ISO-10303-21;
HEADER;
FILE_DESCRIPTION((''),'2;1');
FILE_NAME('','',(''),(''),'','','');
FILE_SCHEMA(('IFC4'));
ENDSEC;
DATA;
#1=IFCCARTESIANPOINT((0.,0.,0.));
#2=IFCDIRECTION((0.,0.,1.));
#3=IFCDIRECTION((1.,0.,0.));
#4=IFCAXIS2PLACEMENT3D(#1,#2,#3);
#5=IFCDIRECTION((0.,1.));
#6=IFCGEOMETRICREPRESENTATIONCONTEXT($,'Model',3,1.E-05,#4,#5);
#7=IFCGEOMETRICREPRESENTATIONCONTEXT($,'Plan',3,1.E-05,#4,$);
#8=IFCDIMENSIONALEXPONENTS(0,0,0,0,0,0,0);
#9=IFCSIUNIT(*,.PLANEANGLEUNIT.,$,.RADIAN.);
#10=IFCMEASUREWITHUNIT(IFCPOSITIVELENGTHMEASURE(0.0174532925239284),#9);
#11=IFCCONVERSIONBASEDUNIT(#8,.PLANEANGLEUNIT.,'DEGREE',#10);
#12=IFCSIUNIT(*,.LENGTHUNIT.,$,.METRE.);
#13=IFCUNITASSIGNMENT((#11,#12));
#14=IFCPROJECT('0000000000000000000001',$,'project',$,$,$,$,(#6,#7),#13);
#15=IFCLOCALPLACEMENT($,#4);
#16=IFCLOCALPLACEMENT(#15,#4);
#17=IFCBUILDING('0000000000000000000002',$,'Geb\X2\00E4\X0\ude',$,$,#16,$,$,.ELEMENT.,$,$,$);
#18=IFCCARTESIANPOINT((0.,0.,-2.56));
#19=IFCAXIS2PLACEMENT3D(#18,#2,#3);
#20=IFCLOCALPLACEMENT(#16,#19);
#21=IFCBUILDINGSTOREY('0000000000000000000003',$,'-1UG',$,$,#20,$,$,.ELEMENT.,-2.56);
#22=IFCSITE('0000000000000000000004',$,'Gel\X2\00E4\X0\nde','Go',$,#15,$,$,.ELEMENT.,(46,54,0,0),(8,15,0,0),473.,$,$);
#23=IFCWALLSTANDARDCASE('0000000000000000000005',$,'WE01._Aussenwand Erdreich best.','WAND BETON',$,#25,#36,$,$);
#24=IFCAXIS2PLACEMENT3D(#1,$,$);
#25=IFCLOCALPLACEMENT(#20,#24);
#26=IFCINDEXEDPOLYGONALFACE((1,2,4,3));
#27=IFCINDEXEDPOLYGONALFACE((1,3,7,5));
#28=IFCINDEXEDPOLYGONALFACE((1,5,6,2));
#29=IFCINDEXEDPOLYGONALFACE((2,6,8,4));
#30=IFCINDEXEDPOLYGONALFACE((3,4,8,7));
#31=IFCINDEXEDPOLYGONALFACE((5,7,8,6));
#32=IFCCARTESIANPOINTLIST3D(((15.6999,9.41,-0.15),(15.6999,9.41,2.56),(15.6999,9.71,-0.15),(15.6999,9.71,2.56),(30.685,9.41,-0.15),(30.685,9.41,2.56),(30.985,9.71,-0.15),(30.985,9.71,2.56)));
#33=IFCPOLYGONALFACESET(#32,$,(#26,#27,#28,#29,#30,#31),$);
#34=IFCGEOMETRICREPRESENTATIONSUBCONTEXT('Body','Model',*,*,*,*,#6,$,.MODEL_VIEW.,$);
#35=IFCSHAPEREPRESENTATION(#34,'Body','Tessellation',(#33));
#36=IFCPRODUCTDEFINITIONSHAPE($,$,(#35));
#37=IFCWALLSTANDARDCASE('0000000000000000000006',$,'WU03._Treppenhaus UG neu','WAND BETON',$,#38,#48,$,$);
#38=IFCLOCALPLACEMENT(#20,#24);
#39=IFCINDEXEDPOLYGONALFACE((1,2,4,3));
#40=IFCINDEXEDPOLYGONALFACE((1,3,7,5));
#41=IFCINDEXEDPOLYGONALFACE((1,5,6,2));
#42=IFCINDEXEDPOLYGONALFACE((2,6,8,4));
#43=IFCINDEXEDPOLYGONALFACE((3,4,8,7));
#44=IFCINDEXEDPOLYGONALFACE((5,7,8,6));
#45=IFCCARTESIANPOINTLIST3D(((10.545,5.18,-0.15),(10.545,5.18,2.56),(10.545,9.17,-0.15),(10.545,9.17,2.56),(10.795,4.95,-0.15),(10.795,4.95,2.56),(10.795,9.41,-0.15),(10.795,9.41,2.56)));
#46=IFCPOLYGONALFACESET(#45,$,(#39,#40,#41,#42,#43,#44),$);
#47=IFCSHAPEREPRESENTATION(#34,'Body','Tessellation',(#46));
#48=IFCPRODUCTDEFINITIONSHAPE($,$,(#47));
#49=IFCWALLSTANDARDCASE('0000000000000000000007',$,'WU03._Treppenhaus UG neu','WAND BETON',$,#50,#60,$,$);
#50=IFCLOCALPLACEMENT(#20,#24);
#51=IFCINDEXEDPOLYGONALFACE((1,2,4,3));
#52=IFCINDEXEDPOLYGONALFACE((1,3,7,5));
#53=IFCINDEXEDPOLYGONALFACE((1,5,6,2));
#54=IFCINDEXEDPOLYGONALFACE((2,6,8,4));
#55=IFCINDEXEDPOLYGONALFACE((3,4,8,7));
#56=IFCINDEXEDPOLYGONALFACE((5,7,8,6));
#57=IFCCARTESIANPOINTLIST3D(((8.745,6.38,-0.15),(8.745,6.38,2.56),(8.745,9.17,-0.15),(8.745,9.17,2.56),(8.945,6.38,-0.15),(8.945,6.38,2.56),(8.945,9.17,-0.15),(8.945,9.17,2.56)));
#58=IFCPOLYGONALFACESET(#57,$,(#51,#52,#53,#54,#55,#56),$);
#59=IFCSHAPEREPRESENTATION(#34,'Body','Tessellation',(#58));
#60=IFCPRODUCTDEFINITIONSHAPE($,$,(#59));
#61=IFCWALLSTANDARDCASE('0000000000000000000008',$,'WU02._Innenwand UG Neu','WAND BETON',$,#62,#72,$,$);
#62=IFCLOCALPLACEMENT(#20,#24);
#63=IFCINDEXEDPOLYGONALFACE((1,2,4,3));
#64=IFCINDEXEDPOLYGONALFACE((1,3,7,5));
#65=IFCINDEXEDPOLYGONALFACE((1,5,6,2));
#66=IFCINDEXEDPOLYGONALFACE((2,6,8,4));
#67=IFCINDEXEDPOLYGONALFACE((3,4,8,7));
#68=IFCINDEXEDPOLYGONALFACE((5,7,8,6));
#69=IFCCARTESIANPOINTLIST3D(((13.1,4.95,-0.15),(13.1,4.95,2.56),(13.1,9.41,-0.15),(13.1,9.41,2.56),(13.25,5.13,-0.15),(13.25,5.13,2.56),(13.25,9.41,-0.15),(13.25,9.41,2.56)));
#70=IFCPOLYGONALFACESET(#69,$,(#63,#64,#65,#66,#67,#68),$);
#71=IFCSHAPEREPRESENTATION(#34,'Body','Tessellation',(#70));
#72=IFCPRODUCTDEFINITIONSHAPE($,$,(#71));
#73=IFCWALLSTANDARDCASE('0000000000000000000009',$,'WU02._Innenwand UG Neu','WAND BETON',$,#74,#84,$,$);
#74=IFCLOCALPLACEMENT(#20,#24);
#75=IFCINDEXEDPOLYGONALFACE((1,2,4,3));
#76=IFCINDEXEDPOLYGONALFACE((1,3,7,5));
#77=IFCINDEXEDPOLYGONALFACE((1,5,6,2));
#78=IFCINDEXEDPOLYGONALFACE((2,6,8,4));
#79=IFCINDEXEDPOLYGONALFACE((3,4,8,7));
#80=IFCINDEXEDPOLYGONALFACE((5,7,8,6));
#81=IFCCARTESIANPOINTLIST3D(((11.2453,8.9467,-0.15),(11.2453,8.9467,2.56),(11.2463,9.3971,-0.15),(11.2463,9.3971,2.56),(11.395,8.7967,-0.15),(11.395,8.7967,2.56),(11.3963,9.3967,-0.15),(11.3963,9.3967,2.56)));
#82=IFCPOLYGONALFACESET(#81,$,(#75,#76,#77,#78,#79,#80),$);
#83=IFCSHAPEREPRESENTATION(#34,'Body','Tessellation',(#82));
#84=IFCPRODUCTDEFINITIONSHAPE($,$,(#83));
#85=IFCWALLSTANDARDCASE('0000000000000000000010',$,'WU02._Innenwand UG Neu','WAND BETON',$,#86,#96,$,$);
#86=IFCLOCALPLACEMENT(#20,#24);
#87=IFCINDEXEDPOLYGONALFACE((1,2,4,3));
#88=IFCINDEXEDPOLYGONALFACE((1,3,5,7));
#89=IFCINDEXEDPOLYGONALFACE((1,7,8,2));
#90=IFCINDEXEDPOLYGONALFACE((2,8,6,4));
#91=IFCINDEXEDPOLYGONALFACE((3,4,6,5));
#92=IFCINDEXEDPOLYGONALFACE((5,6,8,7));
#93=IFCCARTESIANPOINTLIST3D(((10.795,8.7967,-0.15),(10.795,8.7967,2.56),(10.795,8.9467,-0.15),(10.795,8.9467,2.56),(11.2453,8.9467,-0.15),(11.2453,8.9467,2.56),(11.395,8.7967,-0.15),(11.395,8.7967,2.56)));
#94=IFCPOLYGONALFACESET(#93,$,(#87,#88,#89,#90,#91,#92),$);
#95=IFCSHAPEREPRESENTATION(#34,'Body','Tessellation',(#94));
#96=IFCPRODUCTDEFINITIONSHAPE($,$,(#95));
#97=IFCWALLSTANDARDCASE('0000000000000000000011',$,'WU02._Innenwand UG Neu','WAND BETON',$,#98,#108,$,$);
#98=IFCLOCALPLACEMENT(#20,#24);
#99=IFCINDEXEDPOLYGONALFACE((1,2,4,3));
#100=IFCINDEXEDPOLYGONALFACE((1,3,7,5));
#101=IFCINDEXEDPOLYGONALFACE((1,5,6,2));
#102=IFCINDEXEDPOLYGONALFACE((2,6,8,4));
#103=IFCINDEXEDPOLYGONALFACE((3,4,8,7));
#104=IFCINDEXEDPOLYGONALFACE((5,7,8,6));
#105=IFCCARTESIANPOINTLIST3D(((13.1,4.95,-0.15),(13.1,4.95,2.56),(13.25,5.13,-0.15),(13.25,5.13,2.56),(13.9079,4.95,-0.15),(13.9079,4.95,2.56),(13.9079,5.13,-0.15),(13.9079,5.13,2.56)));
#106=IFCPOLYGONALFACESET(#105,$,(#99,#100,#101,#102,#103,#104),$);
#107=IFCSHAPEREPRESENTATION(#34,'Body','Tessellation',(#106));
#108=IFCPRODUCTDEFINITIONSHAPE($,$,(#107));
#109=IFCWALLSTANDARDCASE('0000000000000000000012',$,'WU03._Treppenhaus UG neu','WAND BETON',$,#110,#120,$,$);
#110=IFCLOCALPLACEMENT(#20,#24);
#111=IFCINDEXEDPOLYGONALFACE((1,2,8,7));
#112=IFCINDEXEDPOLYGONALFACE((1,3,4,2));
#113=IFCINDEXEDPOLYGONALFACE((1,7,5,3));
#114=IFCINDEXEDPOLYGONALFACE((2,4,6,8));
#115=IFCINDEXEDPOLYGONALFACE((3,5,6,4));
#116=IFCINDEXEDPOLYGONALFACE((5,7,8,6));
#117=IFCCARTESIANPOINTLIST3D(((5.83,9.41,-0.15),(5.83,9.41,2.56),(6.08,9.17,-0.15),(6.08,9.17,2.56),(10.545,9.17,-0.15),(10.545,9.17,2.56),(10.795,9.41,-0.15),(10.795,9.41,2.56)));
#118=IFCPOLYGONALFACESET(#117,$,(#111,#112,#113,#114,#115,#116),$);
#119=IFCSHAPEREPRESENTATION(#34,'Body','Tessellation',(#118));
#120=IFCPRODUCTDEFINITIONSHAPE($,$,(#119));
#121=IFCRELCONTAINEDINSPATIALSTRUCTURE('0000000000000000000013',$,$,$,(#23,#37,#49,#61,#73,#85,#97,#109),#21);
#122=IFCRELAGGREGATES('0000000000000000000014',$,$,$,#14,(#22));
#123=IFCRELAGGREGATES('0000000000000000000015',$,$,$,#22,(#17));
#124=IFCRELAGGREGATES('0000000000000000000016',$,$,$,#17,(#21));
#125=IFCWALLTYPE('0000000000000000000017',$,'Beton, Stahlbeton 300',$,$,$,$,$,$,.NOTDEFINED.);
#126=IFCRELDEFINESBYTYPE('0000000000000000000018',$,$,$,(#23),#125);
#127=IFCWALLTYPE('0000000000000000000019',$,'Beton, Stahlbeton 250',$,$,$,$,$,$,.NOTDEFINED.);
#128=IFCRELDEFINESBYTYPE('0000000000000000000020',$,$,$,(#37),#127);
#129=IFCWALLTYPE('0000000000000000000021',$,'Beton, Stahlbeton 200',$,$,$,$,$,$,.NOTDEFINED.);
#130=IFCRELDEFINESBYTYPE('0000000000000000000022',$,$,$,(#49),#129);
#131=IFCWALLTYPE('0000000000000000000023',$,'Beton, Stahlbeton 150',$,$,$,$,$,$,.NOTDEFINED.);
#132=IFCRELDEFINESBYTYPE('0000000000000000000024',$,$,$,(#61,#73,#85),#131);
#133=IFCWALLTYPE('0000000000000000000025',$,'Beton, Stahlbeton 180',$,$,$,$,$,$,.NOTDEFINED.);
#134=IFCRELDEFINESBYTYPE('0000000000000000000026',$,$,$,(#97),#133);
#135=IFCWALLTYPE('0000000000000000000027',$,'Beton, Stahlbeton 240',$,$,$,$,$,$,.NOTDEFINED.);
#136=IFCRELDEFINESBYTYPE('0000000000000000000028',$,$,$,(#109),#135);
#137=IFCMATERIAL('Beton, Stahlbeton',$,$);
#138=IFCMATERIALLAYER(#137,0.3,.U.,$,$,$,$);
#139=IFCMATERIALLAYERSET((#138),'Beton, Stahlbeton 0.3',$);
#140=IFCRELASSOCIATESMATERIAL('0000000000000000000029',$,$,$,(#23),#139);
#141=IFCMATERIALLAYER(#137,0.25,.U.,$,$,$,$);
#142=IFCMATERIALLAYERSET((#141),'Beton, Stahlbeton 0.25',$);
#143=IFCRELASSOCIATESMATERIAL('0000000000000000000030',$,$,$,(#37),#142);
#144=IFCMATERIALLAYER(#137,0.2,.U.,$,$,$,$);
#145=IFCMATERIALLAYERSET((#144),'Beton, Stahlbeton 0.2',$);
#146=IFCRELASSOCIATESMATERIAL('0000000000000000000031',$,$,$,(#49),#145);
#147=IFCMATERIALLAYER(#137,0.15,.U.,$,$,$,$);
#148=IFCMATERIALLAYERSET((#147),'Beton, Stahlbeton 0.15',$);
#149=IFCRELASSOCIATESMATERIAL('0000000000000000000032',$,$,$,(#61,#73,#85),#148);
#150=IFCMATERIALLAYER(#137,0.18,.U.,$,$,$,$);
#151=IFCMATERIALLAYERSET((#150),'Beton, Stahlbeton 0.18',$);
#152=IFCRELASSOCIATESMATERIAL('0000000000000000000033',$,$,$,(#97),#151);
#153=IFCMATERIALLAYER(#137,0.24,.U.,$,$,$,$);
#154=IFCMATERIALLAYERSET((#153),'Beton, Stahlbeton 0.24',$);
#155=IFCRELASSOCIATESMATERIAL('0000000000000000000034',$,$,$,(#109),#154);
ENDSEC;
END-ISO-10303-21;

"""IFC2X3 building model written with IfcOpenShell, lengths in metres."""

from ifc_helpers import new_model, entity, si_unit, converted_unit, direction, frame, origin_with_axes, place, context, subcontext, project, spatial, polyline, outline, extrude, material, layer, layer_set, layer_usage, type_object, element, save


model = new_model("IFC2X3")

# Units and contexts
model_context = context("Model", 3, precision=1e-05, world=origin_with_axes(), true_north=direction((0.0, 1.0)))
plan_context = context("Plan", 3, precision=1e-05, world=origin_with_axes())
body_context = subcontext(model_context, "Body", "Model", "MODEL_VIEW")
ifc_project = project(units=[converted_unit("PLANEANGLEUNIT", "DEGREE", entity("IfcPositiveLengthMeasure", 0.0174532925239284), si_unit("PLANEANGLEUNIT", "RADIAN"), dimensions=[0, 0, 0, 0, 0, 0, 0]), si_unit("LENGTHUNIT", "METRE")], contexts=[model_context, plan_context])

# Site, building, storey
site_placement = place(None, origin_with_axes())
site = spatial("IfcSite", under=ifc_project, at=site_placement, Name="Gelände", Description="Go", CompositionType="ELEMENT", RefLatitude=(46, 54, 0, 0), RefLongitude=(8, 15, 0, 0), RefElevation=473.0)
building_placement = place(site_placement, origin_with_axes())
building = spatial("IfcBuilding", under=site, at=building_placement, Name="Gebäude", CompositionType="ELEMENT")
storey_placement = place(building_placement, frame((0.0, 0.0, -2.56), z_axis=(0.0, 0.0, 1.0), x_axis=(1.0, 0.0, 0.0)))
storey = spatial("IfcBuildingStorey", under=building, at=storey_placement, Name="-1UG", CompositionType="ELEMENT", Elevation=-2.56)

# Shared definitions
ifc_material_1 = material(Name="Beton, Stahlbeton")

# Shared definitions
ifc_layer_1 = layer(ifc_material_1, 0.25, ventilated="UNKNOWN")
ifc_layer_set_1 = layer_set([ifc_layer_1], Name="Beton, Stahlbeton 0.25")

# Walls
ifc_layer_2 = layer(ifc_material_1, 0.3, ventilated="UNKNOWN")
ifc_layer_set_2 = layer_set([ifc_layer_2], Name="Beton, Stahlbeton 0.3")
ifc_layer_usage_1 = layer_usage(ifc_layer_set_2, "AXIS2", "NEGATIVE", 0.3)
wall_type_1 = type_object("IfcWallType", Name="Beton, Stahlbeton 300", PredefinedType="NOTDEFINED")
wall_1_placement = place(storey_placement, frame((15.6999, 9.41, -0.15), z_axis=(0.0, 0.0, 1.0), x_axis=(1.0, 0.0, 0.0)))
element("IfcWallStandardCase", 1, at=wall_1_placement, inside=storey, type_object=wall_type_1, material=ifc_layer_usage_1, Name="WE01._Aussenwand Erdreich best.", Description="WAND BETON", context=body_context, shape_type="SweptSolid", body=[
    extrude(outline(polyline([(0.0, 0.0), (14.9851, 0.0), (15.2851, 0.3), (0.0, 0.3), (0.0, 0.0)])), origin_with_axes(), (0.0, 0.0, 1.0), 2.71),
])
ifc_layer_usage_2 = layer_usage(ifc_layer_set_1, "AXIS2", "POSITIVE", -0.25)
wall_type_2 = type_object("IfcWallType", Name="Beton, Stahlbeton 250", PredefinedType="NOTDEFINED")
wall_2_placement = place(storey_placement, frame((10.545, 5.18, -0.15), z_axis=(0.0, 0.0, 1.0), x_axis=(0.0, 1.0, 0.0)))
element("IfcWallStandardCase", 2, at=wall_2_placement, inside=storey, type_object=wall_type_2, material=ifc_layer_usage_2, Name="WU03._Treppenhaus UG neu", Description="WAND BETON", context=body_context, shape_type="SweptSolid", body=[
    extrude(outline(polyline([(-0.23, -0.25), (4.23, -0.25), (3.99, 0.0), (0.0, 0.0), (-0.23, -0.25)])), origin_with_axes(), (0.0, 0.0, 1.0), 2.71),
])
ifc_layer_3 = layer(ifc_material_1, 0.2, ventilated="UNKNOWN")
ifc_layer_set_3 = layer_set([ifc_layer_3], Name="Beton, Stahlbeton 0.2")
ifc_layer_usage_3 = layer_usage(ifc_layer_set_3, "AXIS2", "NEGATIVE", 0.2)
wall_type_3 = type_object("IfcWallType", Name="Beton, Stahlbeton 200", PredefinedType="NOTDEFINED")
wall_3_placement = place(storey_placement, frame((8.945, 6.38, -0.15), z_axis=(0.0, 0.0, 1.0), x_axis=(0.0, 1.0, 0.0)))
element("IfcWallStandardCase", 3, at=wall_3_placement, inside=storey, type_object=wall_type_3, material=ifc_layer_usage_3, Name="WU03._Treppenhaus UG neu", Description="WAND BETON", context=body_context, shape_type="SweptSolid", body=[
    extrude(outline(polyline([(0.0, 0.0), (2.79, 0.0), (2.79, 0.2), (0.0, 0.2), (0.0, 0.0)])), origin_with_axes(), (0.0, 0.0, 1.0), 2.71),
])
ifc_layer_4 = layer(ifc_material_1, 0.15, ventilated="UNKNOWN")
ifc_layer_set_4 = layer_set([ifc_layer_4], Name="Beton, Stahlbeton 0.15")
ifc_layer_usage_4 = layer_usage(ifc_layer_set_4, "AXIS2", "POSITIVE", 0.0)
wall_type_4 = type_object("IfcWallType", Name="Beton, Stahlbeton 150", PredefinedType="NOTDEFINED")
wall_4_placement = place(storey_placement, frame((13.1, 9.41, -0.15), z_axis=(0.0, 0.0, 1.0), x_axis=(0.0, -1.0, 0.0)))
element("IfcWallStandardCase", 4, at=wall_4_placement, inside=storey, type_object=wall_type_4, material=ifc_layer_usage_4, Name="WU02._Innenwand UG Neu", Description="WAND BETON", context=body_context, shape_type="SweptSolid", body=[
    extrude(outline(polyline([(0.0, 0.0), (4.46, 0.0), (4.28, 0.15), (0.0, 0.15), (0.0, 0.0)])), origin_with_axes(), (0.0, 0.0, 1.0), 2.71),
])
ifc_layer_usage_5 = layer_usage(ifc_layer_set_4, "AXIS2", "POSITIVE", 0.0)
wall_5_placement = place(storey_placement, frame((11.395, 8.7967, -0.15), z_axis=(0.0, 0.0, 1.0), x_axis=(0.002118, 0.999998, 0.0)))
element("IfcWallStandardCase", 5, at=wall_5_placement, inside=storey, type_object=wall_type_4, material=ifc_layer_usage_5, Name="WU02._Innenwand UG Neu", Description="WAND BETON", context=body_context, shape_type="SweptSolid", body=[
    extrude(outline(polyline([(0.0, 0.0), (0.6, 0.0), (0.6, 0.15), (0.1497, 0.15), (0.0, 0.0)])), origin_with_axes(), (0.0, 0.0, 1.0), 2.71),
])
ifc_layer_usage_6 = layer_usage(ifc_layer_set_4, "AXIS2", "POSITIVE", 0.0)
wall_6_placement = place(storey_placement, frame((10.795, 8.7967, -0.15), z_axis=(0.0, 0.0, 1.0), x_axis=(1.0, 0.0, 0.0)))
element("IfcWallStandardCase", 6, at=wall_6_placement, inside=storey, type_object=wall_type_4, material=ifc_layer_usage_6, Name="WU02._Innenwand UG Neu", Description="WAND BETON", context=body_context, shape_type="SweptSolid", body=[
    extrude(outline(polyline([(0.0, 0.0), (0.6, 0.0), (0.4503, 0.15), (0.0, 0.15), (0.0, 0.0)])), origin_with_axes(), (0.0, 0.0, 1.0), 2.71),
])
ifc_layer_5 = layer(ifc_material_1, 0.18, ventilated="UNKNOWN")
ifc_layer_set_5 = layer_set([ifc_layer_5], Name="Beton, Stahlbeton 0.18")
ifc_layer_usage_7 = layer_usage(ifc_layer_set_5, "AXIS2", "POSITIVE", 0.0)
wall_type_5 = type_object("IfcWallType", Name="Beton, Stahlbeton 180", PredefinedType="NOTDEFINED")
wall_7_placement = place(storey_placement, frame((13.1, 4.95, -0.15), z_axis=(0.0, 0.0, 1.0), x_axis=(1.0, 0.0, 0.0)))
element("IfcWallStandardCase", 7, at=wall_7_placement, inside=storey, type_object=wall_type_5, material=ifc_layer_usage_7, Name="WU02._Innenwand UG Neu", Description="WAND BETON", context=body_context, shape_type="SweptSolid", body=[
    extrude(outline(polyline([(0.0, 0.0), (0.8079, 0.0), (0.8079, 0.18), (0.15, 0.18), (0.0, 0.0)])), origin_with_axes(), (0.0, 0.0, 1.0), 2.71),
])
ifc_layer_6 = layer(ifc_material_1, 0.24, ventilated="UNKNOWN")
ifc_layer_set_6 = layer_set([ifc_layer_6], Name="Beton, Stahlbeton 0.24")
ifc_layer_usage_8 = layer_usage(ifc_layer_set_6, "AXIS2", "POSITIVE", -0.24)
wall_type_6 = type_object("IfcWallType", Name="Beton, Stahlbeton 240", PredefinedType="NOTDEFINED")
wall_8_placement = place(storey_placement, frame((10.545, 9.17, -0.15), z_axis=(0.0, 0.0, 1.0), x_axis=(-1.0, 0.0, 0.0)))
element("IfcWallStandardCase", 8, at=wall_8_placement, inside=storey, type_object=wall_type_6, material=ifc_layer_usage_8, Name="WU03._Treppenhaus UG neu", Description="WAND BETON", context=body_context, shape_type="SweptSolid", body=[
    extrude(outline(polyline([(-0.25, -0.24), (4.715, -0.24), (4.465, 0.0), (0.0, 0.0), (-0.25, -0.24)])), origin_with_axes(), (0.0, 0.0, 1.0), 2.71),
])

save(model, "model.ifc")
